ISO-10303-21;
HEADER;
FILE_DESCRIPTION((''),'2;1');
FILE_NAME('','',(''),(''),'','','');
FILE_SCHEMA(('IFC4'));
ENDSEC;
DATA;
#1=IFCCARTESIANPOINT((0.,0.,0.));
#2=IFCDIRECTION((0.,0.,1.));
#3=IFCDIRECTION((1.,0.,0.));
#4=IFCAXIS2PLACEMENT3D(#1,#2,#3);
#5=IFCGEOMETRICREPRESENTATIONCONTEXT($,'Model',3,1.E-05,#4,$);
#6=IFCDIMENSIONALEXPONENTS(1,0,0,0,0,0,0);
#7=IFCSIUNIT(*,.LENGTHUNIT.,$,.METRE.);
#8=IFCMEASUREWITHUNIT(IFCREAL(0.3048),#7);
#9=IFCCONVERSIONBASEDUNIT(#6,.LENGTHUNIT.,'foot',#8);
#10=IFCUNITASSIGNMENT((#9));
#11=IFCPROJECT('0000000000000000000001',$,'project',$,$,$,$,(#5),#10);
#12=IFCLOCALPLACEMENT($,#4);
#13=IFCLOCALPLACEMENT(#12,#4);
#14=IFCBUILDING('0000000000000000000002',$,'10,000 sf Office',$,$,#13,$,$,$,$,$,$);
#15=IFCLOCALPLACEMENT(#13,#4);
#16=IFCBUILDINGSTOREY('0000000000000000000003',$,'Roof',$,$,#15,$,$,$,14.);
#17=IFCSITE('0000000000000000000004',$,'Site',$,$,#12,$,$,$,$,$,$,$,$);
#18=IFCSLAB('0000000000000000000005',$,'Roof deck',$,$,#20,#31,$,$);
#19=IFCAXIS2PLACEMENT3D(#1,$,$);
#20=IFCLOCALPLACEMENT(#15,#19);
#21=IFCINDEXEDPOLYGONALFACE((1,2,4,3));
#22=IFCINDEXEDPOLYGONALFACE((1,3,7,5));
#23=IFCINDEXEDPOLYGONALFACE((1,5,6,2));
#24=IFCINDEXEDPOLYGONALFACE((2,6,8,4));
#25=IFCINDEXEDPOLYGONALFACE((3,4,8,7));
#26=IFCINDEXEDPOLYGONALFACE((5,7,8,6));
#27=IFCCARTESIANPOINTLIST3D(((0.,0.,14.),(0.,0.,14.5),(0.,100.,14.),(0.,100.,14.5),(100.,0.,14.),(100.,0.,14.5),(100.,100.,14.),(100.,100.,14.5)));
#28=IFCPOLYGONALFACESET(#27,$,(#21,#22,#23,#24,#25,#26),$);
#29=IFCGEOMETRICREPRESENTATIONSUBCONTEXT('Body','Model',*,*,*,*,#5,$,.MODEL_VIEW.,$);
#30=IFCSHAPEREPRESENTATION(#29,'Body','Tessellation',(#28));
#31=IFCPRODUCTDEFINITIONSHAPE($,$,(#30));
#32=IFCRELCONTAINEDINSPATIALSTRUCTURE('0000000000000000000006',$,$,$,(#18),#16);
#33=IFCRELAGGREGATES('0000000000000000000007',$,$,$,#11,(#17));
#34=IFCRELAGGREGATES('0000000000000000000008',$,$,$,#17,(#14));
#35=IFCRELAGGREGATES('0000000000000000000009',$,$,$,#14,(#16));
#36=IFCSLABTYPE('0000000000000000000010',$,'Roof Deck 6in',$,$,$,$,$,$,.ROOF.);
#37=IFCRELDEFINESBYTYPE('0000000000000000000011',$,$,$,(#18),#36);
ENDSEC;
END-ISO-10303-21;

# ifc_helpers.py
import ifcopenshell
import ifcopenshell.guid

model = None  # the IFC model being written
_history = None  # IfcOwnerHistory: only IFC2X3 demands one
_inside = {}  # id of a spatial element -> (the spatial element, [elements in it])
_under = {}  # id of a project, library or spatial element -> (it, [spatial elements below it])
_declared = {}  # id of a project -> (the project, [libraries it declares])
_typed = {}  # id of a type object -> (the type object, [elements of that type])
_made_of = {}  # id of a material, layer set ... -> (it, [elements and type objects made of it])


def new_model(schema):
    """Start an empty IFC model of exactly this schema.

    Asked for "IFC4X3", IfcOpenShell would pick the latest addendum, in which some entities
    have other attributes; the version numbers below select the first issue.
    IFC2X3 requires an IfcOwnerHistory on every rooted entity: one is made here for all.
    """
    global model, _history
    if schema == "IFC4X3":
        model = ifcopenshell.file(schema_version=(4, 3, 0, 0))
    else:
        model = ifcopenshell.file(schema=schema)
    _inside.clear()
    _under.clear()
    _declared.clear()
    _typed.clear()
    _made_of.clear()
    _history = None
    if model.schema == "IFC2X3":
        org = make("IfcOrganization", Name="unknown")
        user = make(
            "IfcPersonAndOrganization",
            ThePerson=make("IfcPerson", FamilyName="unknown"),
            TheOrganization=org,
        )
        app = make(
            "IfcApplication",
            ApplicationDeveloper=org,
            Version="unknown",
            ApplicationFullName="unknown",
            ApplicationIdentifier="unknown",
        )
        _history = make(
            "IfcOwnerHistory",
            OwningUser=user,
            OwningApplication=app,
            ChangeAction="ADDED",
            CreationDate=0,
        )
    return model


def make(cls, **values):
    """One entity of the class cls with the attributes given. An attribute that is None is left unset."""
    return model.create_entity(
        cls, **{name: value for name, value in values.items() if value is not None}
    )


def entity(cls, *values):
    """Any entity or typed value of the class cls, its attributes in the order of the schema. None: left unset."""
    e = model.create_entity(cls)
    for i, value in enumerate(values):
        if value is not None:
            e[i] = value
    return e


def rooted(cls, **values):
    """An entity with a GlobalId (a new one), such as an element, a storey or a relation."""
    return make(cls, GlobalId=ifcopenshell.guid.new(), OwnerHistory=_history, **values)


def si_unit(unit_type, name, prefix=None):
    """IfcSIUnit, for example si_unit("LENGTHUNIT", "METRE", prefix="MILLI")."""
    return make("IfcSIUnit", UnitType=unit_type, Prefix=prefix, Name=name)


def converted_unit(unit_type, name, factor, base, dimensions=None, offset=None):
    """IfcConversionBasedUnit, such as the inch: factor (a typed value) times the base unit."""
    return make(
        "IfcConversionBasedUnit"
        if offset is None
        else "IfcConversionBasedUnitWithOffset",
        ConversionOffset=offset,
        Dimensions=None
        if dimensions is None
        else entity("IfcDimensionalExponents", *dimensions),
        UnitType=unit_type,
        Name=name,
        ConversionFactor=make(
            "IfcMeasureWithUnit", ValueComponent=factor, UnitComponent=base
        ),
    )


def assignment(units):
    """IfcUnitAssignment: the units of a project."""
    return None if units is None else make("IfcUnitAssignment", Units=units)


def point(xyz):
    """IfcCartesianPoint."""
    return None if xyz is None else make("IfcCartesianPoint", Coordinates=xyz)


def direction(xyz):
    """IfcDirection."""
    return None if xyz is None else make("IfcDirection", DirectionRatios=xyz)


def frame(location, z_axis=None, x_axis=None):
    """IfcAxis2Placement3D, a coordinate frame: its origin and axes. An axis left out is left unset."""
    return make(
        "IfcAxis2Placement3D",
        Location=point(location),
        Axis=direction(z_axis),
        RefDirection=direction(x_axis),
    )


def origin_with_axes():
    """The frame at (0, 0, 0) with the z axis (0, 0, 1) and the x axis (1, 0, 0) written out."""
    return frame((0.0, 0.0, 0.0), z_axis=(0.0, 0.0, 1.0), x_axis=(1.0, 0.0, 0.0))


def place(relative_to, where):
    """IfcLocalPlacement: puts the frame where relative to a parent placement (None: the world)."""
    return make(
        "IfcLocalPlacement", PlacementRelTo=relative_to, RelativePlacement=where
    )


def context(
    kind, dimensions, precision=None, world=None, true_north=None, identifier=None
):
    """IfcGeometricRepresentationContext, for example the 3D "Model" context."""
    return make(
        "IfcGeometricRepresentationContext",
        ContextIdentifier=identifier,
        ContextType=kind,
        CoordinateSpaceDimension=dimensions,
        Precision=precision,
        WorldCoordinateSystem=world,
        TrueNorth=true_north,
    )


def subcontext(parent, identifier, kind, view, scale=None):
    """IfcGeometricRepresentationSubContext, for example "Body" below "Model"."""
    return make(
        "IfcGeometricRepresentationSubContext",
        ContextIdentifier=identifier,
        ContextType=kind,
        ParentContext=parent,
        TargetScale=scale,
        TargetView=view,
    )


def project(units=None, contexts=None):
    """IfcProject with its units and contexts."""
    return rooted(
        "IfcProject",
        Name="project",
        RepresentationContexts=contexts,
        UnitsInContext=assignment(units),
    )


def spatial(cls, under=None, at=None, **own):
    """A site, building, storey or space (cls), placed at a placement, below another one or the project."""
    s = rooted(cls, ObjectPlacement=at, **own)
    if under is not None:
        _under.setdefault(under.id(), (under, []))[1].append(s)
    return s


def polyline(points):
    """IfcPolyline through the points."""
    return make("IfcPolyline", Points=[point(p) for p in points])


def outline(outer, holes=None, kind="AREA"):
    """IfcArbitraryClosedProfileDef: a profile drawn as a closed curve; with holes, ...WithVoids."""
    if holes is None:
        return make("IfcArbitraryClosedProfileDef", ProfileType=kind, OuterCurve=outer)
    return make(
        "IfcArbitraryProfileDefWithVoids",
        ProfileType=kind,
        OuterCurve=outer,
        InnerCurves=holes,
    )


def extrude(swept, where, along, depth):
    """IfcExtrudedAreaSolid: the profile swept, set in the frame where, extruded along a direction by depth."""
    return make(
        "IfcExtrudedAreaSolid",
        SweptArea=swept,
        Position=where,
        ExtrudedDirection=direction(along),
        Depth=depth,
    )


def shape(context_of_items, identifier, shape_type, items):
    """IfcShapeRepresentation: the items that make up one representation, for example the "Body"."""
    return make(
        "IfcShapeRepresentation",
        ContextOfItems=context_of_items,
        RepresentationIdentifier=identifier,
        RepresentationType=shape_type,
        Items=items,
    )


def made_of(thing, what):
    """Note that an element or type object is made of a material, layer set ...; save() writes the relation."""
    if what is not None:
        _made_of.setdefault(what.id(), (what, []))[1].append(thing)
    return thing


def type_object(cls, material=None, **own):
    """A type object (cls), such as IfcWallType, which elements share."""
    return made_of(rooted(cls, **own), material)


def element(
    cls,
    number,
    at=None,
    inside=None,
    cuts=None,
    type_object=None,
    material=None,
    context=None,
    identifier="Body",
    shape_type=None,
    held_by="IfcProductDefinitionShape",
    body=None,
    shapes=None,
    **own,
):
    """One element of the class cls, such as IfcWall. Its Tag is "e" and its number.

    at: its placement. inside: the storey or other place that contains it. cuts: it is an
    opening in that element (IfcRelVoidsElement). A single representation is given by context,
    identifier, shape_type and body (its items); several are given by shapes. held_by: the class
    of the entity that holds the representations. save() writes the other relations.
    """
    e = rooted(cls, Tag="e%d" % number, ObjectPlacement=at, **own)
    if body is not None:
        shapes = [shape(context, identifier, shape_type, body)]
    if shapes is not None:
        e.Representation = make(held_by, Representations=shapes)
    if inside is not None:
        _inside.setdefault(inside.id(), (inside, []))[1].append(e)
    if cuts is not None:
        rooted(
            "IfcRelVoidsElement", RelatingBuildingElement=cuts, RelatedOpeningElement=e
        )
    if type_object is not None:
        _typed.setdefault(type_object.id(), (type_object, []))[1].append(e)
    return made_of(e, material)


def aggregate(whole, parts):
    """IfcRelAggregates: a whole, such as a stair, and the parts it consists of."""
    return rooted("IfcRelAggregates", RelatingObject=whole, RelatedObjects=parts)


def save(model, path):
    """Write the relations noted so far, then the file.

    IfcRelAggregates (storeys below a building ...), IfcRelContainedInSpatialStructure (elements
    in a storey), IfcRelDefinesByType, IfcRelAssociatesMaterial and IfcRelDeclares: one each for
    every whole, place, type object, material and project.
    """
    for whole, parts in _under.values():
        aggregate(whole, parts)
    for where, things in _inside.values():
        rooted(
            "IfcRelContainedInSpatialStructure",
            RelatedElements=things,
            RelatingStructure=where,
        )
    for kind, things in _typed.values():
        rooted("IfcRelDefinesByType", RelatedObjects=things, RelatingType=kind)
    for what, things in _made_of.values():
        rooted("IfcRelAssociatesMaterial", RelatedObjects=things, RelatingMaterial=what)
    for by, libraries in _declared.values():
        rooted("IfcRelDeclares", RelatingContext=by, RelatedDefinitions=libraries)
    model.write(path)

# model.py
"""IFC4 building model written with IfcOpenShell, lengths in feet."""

from ifc_helpers import new_model, entity, si_unit, converted_unit, frame, origin_with_axes, place, context, subcontext, project, spatial, polyline, outline, extrude, type_object, element, save


model = new_model("IFC4")

# Units and contexts
model_context = context("Model", 3, precision=1e-05, world=origin_with_axes())
body_context = subcontext(model_context, "Body", "Model", "MODEL_VIEW")
ifc_project = project(units=[converted_unit("LENGTHUNIT", "foot", entity("IfcReal", 0.3048), si_unit("LENGTHUNIT", "METRE"), dimensions=[1, 0, 0, 0, 0, 0, 0])], contexts=[model_context])

# Site, building, storey
site_placement = place(None, origin_with_axes())
site = spatial("IfcSite", under=ifc_project, at=site_placement, Name="Site")
building_placement = place(site_placement, origin_with_axes())
building = spatial("IfcBuilding", under=site, at=building_placement, Name="10,000 sf Office")
storey_placement = place(building_placement, origin_with_axes())
storey = spatial("IfcBuildingStorey", under=building, at=storey_placement, Name="Roof", Elevation=14.0)

# Slab
slab_type = type_object("IfcSlabType", Name="Roof Deck 6in", PredefinedType="ROOF")
slab_placement = place(storey_placement, frame((0.0, 0.0, 14.0), z_axis=(0.0, 0.0, 1.0), x_axis=(1.0, 0.0, 0.0)))
element("IfcSlab", 1, at=slab_placement, inside=storey, type_object=slab_type, Name="Roof deck", context=body_context, shape_type="SweptSolid", body=[
    extrude(outline(polyline([(0.0, 0.0), (100.0, 0.0), (100.0, 100.0), (0.0, 100.0), (0.0, 0.0)])), None, (0.0, 0.0, 1.0), 0.5),
])

save(model, "model.ifc")
